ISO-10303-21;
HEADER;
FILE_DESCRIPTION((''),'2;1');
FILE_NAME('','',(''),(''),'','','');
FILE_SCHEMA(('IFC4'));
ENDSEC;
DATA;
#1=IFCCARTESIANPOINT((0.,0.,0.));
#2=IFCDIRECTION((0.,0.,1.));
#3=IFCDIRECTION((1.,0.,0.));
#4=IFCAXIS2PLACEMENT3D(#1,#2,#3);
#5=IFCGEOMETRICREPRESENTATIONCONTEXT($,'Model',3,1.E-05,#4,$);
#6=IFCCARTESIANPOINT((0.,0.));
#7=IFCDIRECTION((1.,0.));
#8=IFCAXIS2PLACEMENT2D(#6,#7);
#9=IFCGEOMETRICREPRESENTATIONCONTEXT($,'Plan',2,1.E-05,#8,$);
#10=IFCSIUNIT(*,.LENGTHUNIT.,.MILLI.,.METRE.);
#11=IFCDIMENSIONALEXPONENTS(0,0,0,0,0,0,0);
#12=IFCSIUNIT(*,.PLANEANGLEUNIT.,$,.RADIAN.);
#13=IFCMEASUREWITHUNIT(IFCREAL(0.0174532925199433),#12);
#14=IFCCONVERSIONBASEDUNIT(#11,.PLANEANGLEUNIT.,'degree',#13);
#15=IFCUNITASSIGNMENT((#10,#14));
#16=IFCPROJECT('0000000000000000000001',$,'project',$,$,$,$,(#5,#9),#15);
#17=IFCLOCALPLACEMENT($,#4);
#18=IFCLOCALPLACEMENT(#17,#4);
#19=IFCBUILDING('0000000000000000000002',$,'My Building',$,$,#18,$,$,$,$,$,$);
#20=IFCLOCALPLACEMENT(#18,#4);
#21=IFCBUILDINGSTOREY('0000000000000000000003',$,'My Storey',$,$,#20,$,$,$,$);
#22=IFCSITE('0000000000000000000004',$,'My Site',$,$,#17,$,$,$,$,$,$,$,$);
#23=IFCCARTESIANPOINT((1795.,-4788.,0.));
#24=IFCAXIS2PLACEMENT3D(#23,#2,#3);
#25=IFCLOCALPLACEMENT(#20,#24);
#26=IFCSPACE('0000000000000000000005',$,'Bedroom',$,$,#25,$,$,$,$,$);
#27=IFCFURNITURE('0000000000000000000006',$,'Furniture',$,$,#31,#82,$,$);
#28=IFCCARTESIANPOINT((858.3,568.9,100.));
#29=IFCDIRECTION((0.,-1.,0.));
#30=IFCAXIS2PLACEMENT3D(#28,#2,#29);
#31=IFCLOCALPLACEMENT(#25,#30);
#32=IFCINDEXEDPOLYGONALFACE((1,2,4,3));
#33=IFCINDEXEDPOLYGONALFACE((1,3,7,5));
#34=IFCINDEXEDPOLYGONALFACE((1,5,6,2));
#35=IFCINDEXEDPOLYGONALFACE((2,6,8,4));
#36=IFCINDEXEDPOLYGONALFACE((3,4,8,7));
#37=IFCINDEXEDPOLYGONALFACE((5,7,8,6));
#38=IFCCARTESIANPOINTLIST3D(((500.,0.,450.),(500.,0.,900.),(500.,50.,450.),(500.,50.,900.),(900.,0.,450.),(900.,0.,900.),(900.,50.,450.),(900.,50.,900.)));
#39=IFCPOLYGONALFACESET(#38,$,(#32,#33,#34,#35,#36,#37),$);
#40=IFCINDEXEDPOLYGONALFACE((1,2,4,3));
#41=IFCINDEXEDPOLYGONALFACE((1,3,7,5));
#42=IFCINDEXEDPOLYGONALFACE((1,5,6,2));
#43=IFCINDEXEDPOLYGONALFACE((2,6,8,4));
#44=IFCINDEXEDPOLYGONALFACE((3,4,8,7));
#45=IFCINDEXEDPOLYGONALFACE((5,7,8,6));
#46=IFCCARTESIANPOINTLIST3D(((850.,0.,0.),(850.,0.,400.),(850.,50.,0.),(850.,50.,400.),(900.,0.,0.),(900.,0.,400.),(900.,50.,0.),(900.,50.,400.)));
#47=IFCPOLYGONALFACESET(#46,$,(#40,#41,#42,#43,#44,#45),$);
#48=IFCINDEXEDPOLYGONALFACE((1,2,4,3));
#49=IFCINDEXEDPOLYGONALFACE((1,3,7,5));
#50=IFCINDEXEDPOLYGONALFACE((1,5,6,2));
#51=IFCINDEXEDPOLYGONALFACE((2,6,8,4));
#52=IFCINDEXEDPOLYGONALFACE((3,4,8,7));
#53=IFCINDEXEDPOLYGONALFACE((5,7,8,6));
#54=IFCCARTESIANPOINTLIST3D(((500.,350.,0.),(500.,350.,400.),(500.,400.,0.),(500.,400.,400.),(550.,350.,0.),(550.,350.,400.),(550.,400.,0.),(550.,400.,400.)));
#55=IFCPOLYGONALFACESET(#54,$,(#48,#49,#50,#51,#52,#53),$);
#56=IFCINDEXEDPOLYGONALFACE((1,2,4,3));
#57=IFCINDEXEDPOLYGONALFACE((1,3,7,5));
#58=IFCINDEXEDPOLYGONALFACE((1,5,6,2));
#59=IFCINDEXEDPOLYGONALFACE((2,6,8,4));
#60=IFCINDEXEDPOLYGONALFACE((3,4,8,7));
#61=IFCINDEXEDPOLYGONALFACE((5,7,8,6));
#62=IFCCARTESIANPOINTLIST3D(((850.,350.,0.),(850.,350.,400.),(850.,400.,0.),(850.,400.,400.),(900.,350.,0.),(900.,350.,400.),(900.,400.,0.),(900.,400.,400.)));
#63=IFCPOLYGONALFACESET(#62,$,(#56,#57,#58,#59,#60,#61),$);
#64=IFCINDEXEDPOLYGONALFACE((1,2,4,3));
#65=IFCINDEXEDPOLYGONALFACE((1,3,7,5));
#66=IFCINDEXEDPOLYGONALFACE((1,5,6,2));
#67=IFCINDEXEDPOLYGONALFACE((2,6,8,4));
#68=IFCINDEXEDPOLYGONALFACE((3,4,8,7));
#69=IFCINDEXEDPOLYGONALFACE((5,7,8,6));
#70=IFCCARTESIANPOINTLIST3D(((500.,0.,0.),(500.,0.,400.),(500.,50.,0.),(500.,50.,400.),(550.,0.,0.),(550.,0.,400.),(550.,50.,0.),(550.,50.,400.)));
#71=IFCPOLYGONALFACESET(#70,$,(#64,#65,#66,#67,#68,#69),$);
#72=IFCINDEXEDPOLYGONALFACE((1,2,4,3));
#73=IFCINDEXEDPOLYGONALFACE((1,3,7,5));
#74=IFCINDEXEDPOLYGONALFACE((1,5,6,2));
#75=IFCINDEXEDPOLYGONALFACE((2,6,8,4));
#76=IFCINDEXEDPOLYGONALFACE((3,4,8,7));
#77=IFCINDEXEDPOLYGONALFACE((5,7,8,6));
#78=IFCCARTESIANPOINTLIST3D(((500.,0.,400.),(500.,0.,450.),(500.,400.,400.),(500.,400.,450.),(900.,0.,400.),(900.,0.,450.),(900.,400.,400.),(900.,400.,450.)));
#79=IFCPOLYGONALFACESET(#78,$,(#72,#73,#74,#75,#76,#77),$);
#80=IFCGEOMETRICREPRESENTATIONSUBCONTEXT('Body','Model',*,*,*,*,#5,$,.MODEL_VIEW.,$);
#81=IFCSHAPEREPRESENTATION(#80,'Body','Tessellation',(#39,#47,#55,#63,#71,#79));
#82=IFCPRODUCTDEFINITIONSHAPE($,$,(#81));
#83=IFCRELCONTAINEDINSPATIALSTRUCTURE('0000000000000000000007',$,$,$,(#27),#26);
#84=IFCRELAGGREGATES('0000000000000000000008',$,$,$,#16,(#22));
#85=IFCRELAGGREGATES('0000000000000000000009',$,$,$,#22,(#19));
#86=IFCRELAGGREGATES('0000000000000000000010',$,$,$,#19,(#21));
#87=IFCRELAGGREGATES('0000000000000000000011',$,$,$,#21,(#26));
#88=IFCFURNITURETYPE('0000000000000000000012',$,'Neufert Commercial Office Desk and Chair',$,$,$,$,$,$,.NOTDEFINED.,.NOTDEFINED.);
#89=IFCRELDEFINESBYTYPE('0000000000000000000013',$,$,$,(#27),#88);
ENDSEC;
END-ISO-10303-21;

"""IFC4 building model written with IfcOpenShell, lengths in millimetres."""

from ifc_helpers import new_model, entity, si_unit, converted_unit, frame, origin_with_axes, origin_2d_with_axis, place, context, subcontext, project, spatial, line, indexed_curve, outline, extrude, shape, source, transform, mapped, type_object, type_shapes, element, save


model = new_model("IFC4")

# Units and contexts
model_context = context("Model", 3, precision=1e-05, world=origin_with_axes())
plan_context = context("Plan", 2, precision=1e-05, world=origin_2d_with_axis())
body_context_1 = subcontext(model_context, "Body", "Model", "MODEL_VIEW")
body_context_2 = subcontext(plan_context, "Body", "Plan", "PLAN_VIEW")
ifc_project = project(units=[si_unit("LENGTHUNIT", "METRE", prefix="MILLI"), converted_unit("PLANEANGLEUNIT", "degree", entity("IfcReal", 0.0174532925199433), si_unit("PLANEANGLEUNIT", "RADIAN"), dimensions=[0, 0, 0, 0, 0, 0, 0])], contexts=[model_context, plan_context])

# Site, building, storey
site_placement = place(None, origin_with_axes())
site = spatial("IfcSite", under=ifc_project, at=site_placement, Name="My Site")
building_placement = place(site_placement, origin_with_axes())
building = spatial("IfcBuilding", under=site, at=building_placement, Name="My Building")
storey_placement = place(building_placement, origin_with_axes())
storey = spatial("IfcBuildingStorey", under=building, at=storey_placement, Name="My Storey")

# Shared definitions
space_1_placement = place(storey_placement, frame((1795.0, -4788.0, 0.0), z_axis=(0.0, 0.0, 1.0), x_axis=(1.0, 0.0, 0.0)))
space_1 = spatial("IfcSpace", under=storey, at=space_1_placement, Name="Bedroom")

# Furniture
furniture_type_1 = type_object("IfcFurnitureType", Name="Neufert Commercial Office Desk and Chair", AssemblyPlace="NOTDEFINED", PredefinedType="NOTDEFINED")
shared_shape_1 = source(origin_with_axes(), body_context_1, "Body", "SweptSolid", [
    extrude(outline(indexed_curve([(-200.0, 0.0), (200.0, 0.0), (200.0, 50.0), (-200.0, 50.0)], segments=[line(4, 1), line(1, 2), line(2, 3), line(3, 4)], self_intersect=False)), frame((700.0, 0.0, 900.0), z_axis=(0.0, 0.0, 1.0), x_axis=(1.0, 0.0, 0.0)), (0.0, 0.0, -1.0), 450.0),
    extrude(outline(indexed_curve([(200.0, 0.0), (150.0, 0.0), (150.0, 50.0), (200.0, 50.0)], segments=[line(1, 2, 3, 4, 1)])), frame((700.0, 0.0, 0.0), z_axis=(0.0, 0.0, 1.0), x_axis=(1.0, 0.0, 0.0)), (0.0, 0.0, 1.0), 400.0),
    extrude(outline(indexed_curve([(-200.0, 400.0), (-150.0, 400.0), (-150.0, 350.0), (-200.0, 350.0)], segments=[line(1, 2, 3, 4, 1)])), frame((700.0, 0.0, 0.0), z_axis=(0.0, 0.0, 1.0), x_axis=(1.0, 0.0, 0.0)), (0.0, 0.0, 1.0), 400.0),
    extrude(outline(indexed_curve([(200.0, 400.0), (150.0, 400.0), (150.0, 350.0), (200.0, 350.0)], segments=[line(1, 2, 3, 4, 1)])), frame((700.0, 0.0, 0.0), z_axis=(0.0, 0.0, 1.0), x_axis=(1.0, 0.0, 0.0)), (0.0, 0.0, 1.0), 400.0),
    extrude(outline(indexed_curve([(-200.0, 0.0), (-150.0, 0.0), (-150.0, 50.0), (-200.0, 50.0)], segments=[line(1, 2, 3, 4, 1)])), frame((700.0, 0.0, 0.0), z_axis=(0.0, 0.0, 1.0), x_axis=(1.0, 0.0, 0.0)), (0.0, 0.0, 1.0), 400.0),
    extrude(outline(indexed_curve([(-200.0, 0.0), (200.0, 0.0), (200.0, 400.0), (-200.0, 400.0)], segments=[line(1, 2, 3, 4, 1)])), frame((700.0, 0.0, 450.0), z_axis=(0.0, 0.0, 1.0), x_axis=(1.0, 0.0, 0.0)), (0.0, 0.0, -1.0), 50.0),
])
shared_shape_2 = source(origin_with_axes(), body_context_2, "Body", "Curve2D", [
    entity("IfcIndexedPolyCurve", entity("IfcCartesianPointList2D", [[0.0, 450.0], [1400.0, 450.0], [1400.0, 1150.0], [0.0, 1150.0]]), [entity("IfcLineIndex", [1, 2, 3, 4, 1])]),
    entity("IfcIndexedPolyCurve", entity("IfcCartesianPointList2D", [[500.0, 400.0], [900.0, 400.0]])),
    entity("IfcIndexedPolyCurve", entity("IfcCartesianPointList2D", [[500.0, 400.0], [500.0, 200.0], [558.6, 58.6], [700.0, 0.0], [841.4, 58.6], [900.0, 200.0], [900.0, 400.0]]), [entity("IfcLineIndex", [1, 2]), entity("IfcArcIndex", [2, 3, 4]), entity("IfcArcIndex", [4, 5, 6]), entity("IfcLineIndex", [6, 7])]),
    entity("IfcIndexedPolyCurve", entity("IfcCartesianPointList2D", [[540.0, 400.0], [540.0, 200.0], [586.9, 86.9], [700.0, 40.0], [813.1, 86.9], [860.0, 200.0], [860.0, 400.0]]), [entity("IfcLineIndex", [1, 2]), entity("IfcArcIndex", [2, 3, 4]), entity("IfcArcIndex", [4, 5, 6]), entity("IfcLineIndex", [6, 7])]),
])
type_shapes(furniture_type_1, [shared_shape_1, shared_shape_2])
furniture_1_placement = place(space_1_placement, frame((858.3, 568.9, 100.0), z_axis=(0.0, 0.0, 1.0), x_axis=(0.0, -1.0, 0.0)))
element("IfcFurniture", 1, at=furniture_1_placement, inside=space_1, type_object=furniture_type_1, Name="Furniture", shapes=[
    shape(body_context_1, "Body", "MappedRepresentation", [mapped(shared_shape_1, transform((0.0, 0.0, 0.0), x_axis=(1.0, 0.0, 0.0), y_axis=(0.0, 1.0, 0.0), z_axis=(0.0, 0.0, 1.0), scale=1.0))]),
    shape(body_context_2, "Body", "MappedRepresentation", [mapped(shared_shape_2, transform((0.0, 0.0, 0.0), x_axis=(1.0, 0.0, 0.0), y_axis=(0.0, 1.0, 0.0), z_axis=(0.0, 0.0, 1.0), scale=1.0))]),
])

save(model, "model.ifc")
